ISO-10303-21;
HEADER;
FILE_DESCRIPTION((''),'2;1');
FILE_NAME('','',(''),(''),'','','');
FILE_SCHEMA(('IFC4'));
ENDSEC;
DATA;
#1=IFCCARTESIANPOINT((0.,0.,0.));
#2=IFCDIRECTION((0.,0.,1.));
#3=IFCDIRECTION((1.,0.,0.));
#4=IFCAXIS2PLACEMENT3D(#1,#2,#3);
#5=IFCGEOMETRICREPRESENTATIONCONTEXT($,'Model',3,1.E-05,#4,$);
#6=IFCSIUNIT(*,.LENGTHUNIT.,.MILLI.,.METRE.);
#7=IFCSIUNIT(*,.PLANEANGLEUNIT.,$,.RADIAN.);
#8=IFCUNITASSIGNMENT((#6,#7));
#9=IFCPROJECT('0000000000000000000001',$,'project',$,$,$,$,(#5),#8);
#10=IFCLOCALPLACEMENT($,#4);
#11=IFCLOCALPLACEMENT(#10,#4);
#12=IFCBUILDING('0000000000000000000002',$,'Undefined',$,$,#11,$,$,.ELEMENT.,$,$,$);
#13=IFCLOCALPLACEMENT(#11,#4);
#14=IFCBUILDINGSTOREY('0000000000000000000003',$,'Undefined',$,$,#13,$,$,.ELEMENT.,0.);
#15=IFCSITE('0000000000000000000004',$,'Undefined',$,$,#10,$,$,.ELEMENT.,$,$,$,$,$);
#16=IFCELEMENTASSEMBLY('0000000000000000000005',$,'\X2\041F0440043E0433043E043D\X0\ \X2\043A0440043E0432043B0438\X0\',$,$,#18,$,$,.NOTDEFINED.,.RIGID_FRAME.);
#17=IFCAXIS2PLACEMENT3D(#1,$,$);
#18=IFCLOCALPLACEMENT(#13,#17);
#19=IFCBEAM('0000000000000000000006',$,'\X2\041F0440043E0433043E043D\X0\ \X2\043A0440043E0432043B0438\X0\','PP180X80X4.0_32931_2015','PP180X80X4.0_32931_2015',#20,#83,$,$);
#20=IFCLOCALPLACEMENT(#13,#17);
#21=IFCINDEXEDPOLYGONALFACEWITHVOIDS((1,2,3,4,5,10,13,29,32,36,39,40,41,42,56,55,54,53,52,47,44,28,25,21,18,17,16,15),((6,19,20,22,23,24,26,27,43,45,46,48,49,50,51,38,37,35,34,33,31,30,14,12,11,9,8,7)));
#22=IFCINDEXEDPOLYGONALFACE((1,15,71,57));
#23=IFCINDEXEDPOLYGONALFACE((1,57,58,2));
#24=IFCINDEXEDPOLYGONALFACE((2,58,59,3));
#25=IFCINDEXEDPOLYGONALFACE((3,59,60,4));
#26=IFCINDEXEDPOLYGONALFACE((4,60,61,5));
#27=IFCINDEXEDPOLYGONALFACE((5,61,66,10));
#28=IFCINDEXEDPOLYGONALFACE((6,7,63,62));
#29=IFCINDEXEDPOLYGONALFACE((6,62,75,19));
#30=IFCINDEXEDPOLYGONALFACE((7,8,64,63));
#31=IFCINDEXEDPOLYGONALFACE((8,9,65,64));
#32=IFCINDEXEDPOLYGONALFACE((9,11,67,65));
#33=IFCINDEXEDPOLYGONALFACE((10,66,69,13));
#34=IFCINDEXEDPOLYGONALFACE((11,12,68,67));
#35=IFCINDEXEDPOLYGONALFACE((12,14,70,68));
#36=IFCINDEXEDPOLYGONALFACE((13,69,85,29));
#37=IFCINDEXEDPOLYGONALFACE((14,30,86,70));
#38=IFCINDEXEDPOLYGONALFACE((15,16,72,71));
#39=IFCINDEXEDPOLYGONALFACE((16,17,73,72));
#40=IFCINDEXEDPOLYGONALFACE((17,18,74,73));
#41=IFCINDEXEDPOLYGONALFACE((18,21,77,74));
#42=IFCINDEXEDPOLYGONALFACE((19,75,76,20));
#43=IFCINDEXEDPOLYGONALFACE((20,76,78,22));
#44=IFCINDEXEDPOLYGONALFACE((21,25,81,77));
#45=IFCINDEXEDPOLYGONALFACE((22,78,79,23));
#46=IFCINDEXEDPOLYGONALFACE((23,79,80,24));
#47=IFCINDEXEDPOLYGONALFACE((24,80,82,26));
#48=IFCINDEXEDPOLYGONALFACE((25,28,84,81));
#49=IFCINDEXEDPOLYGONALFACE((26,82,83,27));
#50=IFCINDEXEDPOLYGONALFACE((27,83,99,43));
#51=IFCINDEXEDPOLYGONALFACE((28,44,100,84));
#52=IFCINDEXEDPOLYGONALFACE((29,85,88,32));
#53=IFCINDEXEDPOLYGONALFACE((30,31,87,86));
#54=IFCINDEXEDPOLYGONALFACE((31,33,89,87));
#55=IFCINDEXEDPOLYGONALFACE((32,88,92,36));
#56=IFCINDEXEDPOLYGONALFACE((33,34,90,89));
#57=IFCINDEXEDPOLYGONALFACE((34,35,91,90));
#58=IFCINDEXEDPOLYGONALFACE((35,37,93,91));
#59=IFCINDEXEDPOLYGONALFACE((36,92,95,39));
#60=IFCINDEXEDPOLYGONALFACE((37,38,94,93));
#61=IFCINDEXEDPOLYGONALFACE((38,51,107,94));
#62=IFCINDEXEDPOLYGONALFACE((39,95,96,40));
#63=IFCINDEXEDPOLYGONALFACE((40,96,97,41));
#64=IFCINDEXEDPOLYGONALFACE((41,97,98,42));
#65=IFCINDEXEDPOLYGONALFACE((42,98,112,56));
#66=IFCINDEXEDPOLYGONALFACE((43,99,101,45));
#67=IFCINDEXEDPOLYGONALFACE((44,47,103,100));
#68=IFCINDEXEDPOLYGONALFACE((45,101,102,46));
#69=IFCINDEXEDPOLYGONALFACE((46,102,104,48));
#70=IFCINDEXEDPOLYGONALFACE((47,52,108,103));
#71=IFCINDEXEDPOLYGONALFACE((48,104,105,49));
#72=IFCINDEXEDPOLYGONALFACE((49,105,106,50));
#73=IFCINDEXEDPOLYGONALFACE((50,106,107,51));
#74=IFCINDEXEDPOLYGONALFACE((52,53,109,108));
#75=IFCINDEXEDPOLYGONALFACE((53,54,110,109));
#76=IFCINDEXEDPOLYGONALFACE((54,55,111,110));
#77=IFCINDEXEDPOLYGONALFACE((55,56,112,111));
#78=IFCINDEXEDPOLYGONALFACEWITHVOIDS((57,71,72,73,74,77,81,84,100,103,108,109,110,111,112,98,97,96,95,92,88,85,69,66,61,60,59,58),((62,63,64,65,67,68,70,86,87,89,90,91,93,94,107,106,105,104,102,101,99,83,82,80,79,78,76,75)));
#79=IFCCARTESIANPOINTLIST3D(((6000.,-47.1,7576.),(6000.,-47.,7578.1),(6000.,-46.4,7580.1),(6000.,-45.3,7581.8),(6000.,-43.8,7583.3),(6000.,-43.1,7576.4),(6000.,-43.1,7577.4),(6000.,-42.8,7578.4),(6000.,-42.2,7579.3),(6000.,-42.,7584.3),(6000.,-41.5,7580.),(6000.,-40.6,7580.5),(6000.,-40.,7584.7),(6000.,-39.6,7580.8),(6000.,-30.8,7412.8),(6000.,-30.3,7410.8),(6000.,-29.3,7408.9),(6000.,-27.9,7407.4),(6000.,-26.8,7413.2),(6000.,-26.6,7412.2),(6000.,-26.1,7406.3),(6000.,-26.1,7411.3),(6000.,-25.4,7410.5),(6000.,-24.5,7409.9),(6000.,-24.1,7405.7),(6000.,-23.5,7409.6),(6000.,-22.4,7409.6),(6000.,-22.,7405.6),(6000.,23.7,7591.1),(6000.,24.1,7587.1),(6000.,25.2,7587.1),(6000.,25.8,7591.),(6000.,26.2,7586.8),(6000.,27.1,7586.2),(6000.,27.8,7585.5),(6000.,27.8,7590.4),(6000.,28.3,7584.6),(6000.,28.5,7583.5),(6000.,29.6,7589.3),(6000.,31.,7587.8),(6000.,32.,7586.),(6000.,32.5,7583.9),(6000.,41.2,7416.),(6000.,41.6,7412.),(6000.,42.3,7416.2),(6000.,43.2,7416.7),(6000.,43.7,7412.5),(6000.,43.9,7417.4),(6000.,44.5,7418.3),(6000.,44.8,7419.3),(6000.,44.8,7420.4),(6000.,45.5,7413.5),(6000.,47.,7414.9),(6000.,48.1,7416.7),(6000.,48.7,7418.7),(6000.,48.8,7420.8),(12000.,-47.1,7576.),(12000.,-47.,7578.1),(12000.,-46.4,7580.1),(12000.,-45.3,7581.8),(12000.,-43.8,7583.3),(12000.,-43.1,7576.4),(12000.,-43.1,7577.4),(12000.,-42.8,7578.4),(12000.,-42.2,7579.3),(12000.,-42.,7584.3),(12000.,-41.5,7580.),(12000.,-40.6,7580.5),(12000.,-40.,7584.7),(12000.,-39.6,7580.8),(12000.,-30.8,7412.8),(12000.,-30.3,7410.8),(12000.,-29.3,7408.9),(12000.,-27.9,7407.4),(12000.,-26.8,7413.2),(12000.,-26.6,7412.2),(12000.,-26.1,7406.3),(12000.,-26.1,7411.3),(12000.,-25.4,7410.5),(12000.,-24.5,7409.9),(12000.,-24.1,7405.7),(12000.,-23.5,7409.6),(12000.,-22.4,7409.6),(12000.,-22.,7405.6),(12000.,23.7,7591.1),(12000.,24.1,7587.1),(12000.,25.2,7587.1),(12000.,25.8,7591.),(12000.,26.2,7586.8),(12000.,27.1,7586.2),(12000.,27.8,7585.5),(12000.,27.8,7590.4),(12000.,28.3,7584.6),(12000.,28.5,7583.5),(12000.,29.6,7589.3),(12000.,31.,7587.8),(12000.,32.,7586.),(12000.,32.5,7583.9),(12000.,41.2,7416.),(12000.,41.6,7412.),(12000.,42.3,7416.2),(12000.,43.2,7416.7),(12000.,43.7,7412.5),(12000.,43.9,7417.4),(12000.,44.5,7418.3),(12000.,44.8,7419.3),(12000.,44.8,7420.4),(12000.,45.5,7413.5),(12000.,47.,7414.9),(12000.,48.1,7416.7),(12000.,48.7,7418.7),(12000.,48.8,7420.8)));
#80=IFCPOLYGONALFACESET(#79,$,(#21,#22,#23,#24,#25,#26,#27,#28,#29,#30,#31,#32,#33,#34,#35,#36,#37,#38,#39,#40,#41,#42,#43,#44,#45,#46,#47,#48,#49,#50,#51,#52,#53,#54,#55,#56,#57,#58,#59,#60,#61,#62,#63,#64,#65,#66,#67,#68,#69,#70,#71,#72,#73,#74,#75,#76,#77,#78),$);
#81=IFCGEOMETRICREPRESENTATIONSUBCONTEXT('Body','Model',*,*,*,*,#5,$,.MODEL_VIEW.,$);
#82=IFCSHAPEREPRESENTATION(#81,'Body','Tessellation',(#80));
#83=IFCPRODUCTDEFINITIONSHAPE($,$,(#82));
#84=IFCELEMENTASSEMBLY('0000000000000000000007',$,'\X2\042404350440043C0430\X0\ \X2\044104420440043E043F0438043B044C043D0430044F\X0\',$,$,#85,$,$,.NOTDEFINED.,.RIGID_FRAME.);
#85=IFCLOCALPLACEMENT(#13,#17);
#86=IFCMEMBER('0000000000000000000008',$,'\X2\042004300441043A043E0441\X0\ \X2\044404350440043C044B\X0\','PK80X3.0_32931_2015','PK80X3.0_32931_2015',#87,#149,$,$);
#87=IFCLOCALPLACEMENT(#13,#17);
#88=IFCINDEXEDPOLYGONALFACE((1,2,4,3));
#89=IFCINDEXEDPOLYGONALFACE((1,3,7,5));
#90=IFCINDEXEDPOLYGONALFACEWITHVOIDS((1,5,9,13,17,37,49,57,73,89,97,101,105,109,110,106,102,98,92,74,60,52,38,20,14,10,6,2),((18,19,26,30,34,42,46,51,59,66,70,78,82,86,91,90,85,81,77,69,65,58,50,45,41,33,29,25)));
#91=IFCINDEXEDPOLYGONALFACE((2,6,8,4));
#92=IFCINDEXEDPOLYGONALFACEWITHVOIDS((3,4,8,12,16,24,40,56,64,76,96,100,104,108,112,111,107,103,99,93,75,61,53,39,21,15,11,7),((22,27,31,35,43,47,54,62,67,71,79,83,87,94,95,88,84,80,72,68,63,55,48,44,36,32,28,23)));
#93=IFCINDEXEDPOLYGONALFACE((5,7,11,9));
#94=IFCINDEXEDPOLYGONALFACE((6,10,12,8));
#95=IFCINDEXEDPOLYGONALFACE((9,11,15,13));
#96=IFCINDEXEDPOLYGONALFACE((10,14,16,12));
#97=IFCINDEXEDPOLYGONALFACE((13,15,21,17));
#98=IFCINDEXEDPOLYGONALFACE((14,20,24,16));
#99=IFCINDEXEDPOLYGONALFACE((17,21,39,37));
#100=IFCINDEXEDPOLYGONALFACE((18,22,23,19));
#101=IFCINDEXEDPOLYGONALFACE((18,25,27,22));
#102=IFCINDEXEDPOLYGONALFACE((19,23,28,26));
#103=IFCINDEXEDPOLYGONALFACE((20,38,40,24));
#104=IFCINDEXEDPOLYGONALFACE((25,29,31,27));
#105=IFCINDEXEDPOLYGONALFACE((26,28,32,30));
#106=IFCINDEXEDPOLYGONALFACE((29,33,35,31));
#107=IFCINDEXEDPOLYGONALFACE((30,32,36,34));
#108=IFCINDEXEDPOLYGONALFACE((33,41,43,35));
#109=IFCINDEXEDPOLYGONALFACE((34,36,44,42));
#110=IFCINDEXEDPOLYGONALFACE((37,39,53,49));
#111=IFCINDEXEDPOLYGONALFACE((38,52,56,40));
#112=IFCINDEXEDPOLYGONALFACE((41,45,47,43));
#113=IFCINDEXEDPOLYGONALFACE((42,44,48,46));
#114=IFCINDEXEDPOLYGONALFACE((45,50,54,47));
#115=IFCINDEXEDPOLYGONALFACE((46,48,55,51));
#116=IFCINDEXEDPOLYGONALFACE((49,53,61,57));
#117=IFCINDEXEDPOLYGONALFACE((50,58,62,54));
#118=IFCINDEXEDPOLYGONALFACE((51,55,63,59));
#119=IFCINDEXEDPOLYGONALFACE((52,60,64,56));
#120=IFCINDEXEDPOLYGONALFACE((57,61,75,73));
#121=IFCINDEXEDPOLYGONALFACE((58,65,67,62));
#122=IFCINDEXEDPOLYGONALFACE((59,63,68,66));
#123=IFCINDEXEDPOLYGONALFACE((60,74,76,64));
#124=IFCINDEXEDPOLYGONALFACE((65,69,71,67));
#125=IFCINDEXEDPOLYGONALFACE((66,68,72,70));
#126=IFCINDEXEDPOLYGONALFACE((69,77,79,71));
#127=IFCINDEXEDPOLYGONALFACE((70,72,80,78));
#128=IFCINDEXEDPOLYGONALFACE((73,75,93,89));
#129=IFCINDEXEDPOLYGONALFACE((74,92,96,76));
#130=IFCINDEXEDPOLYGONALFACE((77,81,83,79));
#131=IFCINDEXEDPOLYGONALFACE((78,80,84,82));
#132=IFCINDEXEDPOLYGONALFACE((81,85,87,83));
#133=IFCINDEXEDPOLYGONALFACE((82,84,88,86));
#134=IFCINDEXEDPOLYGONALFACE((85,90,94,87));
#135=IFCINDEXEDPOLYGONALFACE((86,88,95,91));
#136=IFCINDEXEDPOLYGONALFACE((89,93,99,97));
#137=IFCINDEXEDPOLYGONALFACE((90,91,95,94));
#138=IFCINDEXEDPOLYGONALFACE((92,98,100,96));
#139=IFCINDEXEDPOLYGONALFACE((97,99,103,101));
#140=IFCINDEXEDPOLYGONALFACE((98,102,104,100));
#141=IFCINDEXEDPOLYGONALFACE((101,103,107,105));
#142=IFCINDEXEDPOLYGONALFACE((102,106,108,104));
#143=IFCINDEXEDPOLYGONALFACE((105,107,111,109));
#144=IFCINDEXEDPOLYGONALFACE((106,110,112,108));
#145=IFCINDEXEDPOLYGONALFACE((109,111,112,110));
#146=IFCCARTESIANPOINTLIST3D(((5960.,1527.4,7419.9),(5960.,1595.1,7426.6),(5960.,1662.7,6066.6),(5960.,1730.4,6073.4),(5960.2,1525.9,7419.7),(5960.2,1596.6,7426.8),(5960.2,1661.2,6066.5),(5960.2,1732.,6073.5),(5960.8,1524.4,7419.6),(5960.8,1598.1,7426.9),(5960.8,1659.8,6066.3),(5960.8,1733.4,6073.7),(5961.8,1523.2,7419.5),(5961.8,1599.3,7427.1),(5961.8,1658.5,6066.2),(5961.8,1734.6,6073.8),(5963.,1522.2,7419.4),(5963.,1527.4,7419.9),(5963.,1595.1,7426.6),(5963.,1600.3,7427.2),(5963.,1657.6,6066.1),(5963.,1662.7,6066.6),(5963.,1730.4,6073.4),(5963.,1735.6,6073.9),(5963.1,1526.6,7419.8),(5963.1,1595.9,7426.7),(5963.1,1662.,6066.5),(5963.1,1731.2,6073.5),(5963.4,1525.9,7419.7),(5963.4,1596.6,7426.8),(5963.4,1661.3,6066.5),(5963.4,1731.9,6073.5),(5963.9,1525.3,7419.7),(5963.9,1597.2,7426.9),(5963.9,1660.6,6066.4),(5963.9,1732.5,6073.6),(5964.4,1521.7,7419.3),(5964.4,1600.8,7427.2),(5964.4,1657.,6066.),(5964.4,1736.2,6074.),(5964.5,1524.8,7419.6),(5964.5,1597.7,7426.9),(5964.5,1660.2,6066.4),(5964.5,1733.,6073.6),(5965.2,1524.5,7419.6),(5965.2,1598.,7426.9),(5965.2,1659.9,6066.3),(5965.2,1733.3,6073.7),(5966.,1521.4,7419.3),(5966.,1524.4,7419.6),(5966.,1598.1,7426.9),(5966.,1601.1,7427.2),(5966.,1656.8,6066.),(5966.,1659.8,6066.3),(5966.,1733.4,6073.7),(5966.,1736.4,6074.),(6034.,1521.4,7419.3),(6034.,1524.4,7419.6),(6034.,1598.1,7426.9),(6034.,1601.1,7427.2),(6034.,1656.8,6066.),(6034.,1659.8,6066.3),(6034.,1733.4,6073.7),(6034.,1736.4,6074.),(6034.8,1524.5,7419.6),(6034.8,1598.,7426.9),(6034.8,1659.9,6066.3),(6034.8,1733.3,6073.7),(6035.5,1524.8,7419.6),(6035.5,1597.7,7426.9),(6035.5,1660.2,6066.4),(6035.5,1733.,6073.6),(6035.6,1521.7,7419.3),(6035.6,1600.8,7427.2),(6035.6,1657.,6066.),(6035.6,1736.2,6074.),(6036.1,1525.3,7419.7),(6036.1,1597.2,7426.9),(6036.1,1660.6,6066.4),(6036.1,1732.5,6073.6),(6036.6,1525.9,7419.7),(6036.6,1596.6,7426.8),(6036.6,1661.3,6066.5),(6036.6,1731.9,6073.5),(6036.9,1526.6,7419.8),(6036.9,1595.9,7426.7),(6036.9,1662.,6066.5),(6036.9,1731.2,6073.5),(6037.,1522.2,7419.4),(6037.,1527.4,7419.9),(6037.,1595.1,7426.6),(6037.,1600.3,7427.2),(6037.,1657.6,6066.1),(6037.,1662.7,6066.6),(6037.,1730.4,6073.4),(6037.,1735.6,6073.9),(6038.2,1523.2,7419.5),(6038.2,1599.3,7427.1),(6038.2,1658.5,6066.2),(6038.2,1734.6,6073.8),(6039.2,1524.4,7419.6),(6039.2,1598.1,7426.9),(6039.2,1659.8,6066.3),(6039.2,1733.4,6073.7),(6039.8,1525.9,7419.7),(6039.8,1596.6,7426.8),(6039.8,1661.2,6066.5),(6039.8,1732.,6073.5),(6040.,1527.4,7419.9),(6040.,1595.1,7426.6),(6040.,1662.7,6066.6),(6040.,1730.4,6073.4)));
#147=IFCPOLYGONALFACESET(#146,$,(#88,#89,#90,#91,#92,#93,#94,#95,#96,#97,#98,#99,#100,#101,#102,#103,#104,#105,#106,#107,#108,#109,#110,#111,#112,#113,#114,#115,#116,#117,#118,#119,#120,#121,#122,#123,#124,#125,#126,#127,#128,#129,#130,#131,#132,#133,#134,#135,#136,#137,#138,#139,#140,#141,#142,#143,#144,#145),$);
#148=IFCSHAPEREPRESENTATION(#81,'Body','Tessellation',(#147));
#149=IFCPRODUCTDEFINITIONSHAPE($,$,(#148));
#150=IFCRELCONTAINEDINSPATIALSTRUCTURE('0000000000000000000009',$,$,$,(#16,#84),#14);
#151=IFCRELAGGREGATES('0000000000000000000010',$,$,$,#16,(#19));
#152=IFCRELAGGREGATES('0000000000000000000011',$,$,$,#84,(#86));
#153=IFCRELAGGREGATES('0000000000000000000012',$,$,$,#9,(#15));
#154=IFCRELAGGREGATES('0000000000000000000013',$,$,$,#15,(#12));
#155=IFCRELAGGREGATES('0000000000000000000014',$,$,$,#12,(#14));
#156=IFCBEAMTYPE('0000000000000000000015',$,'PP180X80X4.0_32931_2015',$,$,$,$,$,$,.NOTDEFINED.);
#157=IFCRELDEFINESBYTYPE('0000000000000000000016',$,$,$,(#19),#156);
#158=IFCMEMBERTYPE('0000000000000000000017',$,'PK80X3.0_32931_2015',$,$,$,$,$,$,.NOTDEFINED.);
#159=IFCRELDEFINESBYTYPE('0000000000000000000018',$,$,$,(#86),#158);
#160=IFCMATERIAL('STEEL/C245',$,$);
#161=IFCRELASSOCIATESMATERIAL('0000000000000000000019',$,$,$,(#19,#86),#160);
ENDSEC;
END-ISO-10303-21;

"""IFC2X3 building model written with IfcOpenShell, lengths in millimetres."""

from ifc_helpers import new_model, si_unit, frame, origin_with_axes, origin_2d_with_axis, place, context, subcontext, project, spatial, hollow_rectangle, extrude, material, type_object, element, aggregate, save


model = new_model("IFC2X3")

# Units and contexts
model_context = context("Model", 3, precision=1e-05, world=origin_with_axes())
body_context = subcontext(model_context, "Body", "Model", "MODEL_VIEW")
ifc_project = project(units=[si_unit("LENGTHUNIT", "METRE", prefix="MILLI"), si_unit("PLANEANGLEUNIT", "RADIAN")], contexts=[model_context])

# Site, building, storey
site_placement = place(None, origin_with_axes())
site = spatial("IfcSite", under=ifc_project, at=site_placement, Name="Undefined", CompositionType="ELEMENT")
building_placement = place(site_placement, origin_with_axes())
building = spatial("IfcBuilding", under=site, at=building_placement, Name="Undefined", CompositionType="ELEMENT")
storey_placement = place(building_placement, origin_with_axes())
storey = spatial("IfcBuildingStorey", under=building, at=storey_placement, Name="Undefined", CompositionType="ELEMENT", Elevation=0.0)

# Shared definitions
ifc_material_1 = material(Name="STEEL/C245")

# Element assembly, beam
beam_type_1 = type_object("IfcBeamType", Name="PP180X80X4.0_32931_2015", PredefinedType="NOTDEFINED")
assembly_1_placement = place(storey_placement, origin_with_axes())
assembly_1 = element("IfcElementAssembly", 1, at=assembly_1_placement, inside=storey, Name="Прогон кровли", AssemblyPlace="NOTDEFINED", PredefinedType="RIGID_FRAME")
beam_1_placement = place(assembly_1_placement, frame((6000.0, 0.8, 7498.4), z_axis=(0.0, -0.099504, 0.995037), x_axis=(1.0, 0.0, 0.0)))
beam_1 = element("IfcBeam", 2, at=beam_1_placement, type_object=beam_type_1, material=ifc_material_1, Name="Прогон кровли", Description="PP180X80X4.0_32931_2015", ObjectType="PP180X80X4.0_32931_2015", context=body_context, shape_type="SweptSolid", body=[
    extrude(hollow_rectangle(XDim=80.0, YDim=180.0, WallThickness=4.0, InnerFilletRadius=4.0, OuterFilletRadius=8.0, at=origin_2d_with_axis()), frame((6000.0, 0.0, 0.0), z_axis=(-1.0, 0.0, 0.0), x_axis=(0.0, -1.0, 0.0)), (0.0, 0.0, 1.0), 6000.0),
])
aggregate(assembly_1, [beam_1])

# Shared definitions
member_type_1 = type_object("IfcMemberType", Name="PK80X3.0_32931_2015", PredefinedType="NOTDEFINED")

# Element assembly, member
assembly_2_placement = place(storey_placement, origin_with_axes())
assembly_2 = element("IfcElementAssembly", 3, at=assembly_2_placement, inside=storey, Name="Ферма стропильная", AssemblyPlace="NOTDEFINED", PredefinedType="RIGID_FRAME")
member_1_placement = place(assembly_2_placement, frame((6000.0, 1561.3, 7423.3), z_axis=(0.0, 0.995037, 0.099504), x_axis=(0.0, 0.099504, -0.995037)))
member_1 = element("IfcMember", 4, at=member_1_placement, type_object=member_type_1, material=ifc_material_1, Name="Раскос фермы", Description="PK80X3.0_32931_2015", ObjectType="PK80X3.0_32931_2015", context=body_context, shape_type="SweptSolid", body=[
    extrude(hollow_rectangle(XDim=80.0, YDim=80.0, WallThickness=3.0, InnerFilletRadius=3.0, OuterFilletRadius=6.0, at=origin_2d_with_axis()), frame((1360.0, 0.0, 0.0), z_axis=(-1.0, 0.0, 0.0), x_axis=(0.0, -1.0, 0.0)), (0.0, 0.0, 1.0), 1360.0),
])

aggregate(assembly_2, [member_1])

save(model, "model.ifc")
